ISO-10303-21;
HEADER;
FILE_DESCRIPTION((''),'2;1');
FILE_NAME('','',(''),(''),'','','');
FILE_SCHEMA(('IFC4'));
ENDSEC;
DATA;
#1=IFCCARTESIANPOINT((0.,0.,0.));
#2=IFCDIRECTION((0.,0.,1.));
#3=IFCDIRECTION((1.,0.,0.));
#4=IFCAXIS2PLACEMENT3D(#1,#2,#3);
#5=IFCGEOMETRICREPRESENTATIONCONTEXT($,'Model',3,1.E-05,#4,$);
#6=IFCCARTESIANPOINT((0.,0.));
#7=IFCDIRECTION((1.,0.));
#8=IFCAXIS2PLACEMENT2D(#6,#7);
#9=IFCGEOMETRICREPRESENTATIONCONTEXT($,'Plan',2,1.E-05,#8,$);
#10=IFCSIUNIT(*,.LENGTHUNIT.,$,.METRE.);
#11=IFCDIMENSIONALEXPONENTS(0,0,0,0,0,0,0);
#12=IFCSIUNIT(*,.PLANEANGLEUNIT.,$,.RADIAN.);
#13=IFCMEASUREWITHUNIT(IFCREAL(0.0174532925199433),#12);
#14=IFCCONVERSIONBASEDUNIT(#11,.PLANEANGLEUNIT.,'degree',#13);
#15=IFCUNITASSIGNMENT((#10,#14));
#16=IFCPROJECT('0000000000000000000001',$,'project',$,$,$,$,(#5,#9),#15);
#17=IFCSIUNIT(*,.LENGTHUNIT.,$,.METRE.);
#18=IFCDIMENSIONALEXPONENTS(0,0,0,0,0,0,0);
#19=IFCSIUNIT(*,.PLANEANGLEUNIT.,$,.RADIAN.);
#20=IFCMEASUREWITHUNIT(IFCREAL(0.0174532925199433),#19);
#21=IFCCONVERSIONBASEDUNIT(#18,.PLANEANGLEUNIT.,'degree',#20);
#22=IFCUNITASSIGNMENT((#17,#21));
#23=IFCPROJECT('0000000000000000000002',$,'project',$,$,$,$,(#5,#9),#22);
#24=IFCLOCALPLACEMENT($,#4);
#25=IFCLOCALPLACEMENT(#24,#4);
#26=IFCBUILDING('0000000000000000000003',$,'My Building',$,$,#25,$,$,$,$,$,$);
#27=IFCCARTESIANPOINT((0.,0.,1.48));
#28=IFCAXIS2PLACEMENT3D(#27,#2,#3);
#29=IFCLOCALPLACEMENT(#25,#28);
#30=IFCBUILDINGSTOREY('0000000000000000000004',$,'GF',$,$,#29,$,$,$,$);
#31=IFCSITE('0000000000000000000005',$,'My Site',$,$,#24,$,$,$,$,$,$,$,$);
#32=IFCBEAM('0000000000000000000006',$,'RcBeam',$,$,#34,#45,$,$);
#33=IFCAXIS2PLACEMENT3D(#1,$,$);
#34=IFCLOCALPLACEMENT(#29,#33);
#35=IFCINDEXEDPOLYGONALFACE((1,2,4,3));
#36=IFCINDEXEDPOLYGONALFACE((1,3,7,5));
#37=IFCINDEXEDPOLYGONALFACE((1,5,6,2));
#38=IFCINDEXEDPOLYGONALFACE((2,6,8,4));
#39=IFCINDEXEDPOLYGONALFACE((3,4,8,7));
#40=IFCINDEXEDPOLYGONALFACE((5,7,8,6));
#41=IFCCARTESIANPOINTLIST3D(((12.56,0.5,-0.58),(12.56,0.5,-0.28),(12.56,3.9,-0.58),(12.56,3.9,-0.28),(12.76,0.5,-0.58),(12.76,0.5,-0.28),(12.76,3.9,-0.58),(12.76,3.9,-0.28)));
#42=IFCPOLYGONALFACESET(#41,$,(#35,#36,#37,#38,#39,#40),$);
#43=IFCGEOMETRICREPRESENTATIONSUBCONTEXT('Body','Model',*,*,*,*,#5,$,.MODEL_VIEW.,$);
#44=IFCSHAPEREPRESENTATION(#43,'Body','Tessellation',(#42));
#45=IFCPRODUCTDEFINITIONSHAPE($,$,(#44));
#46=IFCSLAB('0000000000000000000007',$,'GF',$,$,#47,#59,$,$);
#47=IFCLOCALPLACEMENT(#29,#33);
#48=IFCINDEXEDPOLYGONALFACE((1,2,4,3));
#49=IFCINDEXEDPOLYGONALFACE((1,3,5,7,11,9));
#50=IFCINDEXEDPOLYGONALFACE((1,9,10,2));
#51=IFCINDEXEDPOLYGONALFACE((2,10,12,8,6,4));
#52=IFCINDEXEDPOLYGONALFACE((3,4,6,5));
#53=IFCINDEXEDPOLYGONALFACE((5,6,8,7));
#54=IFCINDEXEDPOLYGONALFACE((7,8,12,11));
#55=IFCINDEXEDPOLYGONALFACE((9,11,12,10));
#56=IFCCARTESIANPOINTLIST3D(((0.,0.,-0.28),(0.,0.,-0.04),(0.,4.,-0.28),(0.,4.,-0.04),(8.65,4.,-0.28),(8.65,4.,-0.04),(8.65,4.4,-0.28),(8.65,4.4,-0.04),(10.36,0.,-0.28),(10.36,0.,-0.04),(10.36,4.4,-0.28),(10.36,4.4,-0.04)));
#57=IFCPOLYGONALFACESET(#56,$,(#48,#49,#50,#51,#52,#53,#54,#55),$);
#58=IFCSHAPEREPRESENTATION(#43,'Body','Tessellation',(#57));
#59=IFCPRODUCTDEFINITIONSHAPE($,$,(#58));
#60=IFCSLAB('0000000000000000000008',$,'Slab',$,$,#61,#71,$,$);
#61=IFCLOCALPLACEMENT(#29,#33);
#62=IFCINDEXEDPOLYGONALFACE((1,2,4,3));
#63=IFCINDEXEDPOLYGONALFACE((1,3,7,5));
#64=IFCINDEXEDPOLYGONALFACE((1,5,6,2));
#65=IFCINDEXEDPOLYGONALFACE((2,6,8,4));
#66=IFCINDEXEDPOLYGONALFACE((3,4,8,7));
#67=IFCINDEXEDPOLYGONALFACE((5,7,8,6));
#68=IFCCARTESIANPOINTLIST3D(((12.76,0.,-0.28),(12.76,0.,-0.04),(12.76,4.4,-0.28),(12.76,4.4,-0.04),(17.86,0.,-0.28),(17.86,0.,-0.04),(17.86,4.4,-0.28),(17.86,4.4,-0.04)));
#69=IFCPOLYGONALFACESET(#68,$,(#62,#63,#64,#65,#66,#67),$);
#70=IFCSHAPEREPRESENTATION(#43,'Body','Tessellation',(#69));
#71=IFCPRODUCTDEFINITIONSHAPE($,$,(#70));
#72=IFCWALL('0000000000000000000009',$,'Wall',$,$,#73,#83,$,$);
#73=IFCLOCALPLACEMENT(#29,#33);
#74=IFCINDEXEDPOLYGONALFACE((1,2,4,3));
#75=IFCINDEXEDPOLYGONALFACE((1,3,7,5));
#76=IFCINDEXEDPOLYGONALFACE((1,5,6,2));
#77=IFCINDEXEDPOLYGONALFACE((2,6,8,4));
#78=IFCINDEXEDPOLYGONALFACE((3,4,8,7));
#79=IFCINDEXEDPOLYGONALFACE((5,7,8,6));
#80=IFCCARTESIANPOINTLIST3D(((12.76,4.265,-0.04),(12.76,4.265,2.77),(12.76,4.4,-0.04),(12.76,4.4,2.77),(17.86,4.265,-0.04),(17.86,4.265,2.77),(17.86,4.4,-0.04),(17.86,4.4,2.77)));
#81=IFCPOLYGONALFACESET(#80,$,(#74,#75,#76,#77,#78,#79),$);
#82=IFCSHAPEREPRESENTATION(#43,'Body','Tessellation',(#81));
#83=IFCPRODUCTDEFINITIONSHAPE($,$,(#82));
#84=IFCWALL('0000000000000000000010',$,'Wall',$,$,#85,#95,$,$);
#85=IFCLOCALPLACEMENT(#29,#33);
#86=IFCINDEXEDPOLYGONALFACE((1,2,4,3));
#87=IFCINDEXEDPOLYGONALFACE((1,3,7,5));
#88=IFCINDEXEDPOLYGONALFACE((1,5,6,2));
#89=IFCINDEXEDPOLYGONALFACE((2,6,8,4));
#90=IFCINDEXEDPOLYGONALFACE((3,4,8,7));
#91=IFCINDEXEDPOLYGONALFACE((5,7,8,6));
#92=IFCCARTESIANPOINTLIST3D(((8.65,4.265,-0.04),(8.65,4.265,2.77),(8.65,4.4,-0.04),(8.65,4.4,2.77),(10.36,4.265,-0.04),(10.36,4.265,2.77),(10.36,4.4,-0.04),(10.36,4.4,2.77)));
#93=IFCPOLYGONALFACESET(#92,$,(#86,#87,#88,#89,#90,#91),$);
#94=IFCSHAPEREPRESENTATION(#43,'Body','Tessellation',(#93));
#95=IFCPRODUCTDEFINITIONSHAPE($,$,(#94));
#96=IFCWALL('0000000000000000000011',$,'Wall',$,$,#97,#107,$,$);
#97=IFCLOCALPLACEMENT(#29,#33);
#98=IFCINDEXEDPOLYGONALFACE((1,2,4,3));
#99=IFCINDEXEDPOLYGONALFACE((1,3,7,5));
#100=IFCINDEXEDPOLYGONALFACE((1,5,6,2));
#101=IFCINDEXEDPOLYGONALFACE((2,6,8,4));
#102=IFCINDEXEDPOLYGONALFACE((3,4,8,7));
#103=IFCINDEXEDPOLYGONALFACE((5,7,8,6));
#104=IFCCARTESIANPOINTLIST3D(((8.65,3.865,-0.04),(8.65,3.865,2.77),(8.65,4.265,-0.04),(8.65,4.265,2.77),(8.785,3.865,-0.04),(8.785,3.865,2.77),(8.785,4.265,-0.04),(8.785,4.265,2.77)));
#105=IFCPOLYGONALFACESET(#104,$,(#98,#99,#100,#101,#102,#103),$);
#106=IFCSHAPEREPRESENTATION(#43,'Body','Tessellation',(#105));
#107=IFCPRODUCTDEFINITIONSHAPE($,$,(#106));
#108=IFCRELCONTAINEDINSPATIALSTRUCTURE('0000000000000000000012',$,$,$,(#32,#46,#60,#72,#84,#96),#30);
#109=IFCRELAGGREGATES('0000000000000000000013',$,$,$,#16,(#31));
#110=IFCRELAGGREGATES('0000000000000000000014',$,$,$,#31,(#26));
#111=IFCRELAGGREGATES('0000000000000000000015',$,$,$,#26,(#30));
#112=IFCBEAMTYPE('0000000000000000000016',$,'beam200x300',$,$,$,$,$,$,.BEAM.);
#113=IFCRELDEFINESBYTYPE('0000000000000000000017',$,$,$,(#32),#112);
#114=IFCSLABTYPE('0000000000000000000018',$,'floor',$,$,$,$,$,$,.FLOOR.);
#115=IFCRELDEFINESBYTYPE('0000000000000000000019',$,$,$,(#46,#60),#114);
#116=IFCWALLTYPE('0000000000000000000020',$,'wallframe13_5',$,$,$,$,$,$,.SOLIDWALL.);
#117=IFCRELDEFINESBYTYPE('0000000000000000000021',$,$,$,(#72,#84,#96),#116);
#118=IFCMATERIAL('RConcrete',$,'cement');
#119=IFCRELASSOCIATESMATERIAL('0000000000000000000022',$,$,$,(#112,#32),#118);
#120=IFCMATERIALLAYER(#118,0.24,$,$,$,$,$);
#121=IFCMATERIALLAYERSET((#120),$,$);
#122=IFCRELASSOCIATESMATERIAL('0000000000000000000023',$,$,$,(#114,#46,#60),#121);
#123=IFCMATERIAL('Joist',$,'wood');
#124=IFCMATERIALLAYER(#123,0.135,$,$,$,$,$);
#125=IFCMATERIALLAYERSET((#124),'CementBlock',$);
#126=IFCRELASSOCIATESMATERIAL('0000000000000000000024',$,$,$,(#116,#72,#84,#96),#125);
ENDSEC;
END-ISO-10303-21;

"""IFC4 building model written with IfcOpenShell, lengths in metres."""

from ifc_helpers import new_model, entity, si_unit, converted_unit, frame, origin_with_axes, origin_2d_with_axis, place, context, subcontext, project, spatial, line, indexed_curve, rectangle, outline, extrude, clip, halfspace, material, layer, layer_set, layer_usage, material_profile, profile_set, profile_usage, type_object, element, save


model = new_model("IFC4")

# Units and contexts
model_context = context("Model", 3, precision=1e-05, world=origin_with_axes())
plan_context = context("Plan", 2, precision=1e-05, world=origin_2d_with_axis())
body_context = subcontext(model_context, "Body", "Model", "MODEL_VIEW")
ifc_project_1 = project(units=[si_unit("LENGTHUNIT", "METRE"), converted_unit("PLANEANGLEUNIT", "degree", entity("IfcReal", 0.0174532925199433), si_unit("PLANEANGLEUNIT", "RADIAN"), dimensions=[0, 0, 0, 0, 0, 0, 0])], contexts=[model_context, plan_context])
ifc_project_2 = project(units=[si_unit("LENGTHUNIT", "METRE"), converted_unit("PLANEANGLEUNIT", "degree", entity("IfcReal", 0.0174532925199433), si_unit("PLANEANGLEUNIT", "RADIAN"), dimensions=[0, 0, 0, 0, 0, 0, 0])], contexts=[model_context, plan_context])

# Site, building, storey
site_placement = place(None, origin_with_axes())
site = spatial("IfcSite", under=ifc_project_1, at=site_placement, Name="My Site")
building_placement = place(site_placement, origin_with_axes())
building = spatial("IfcBuilding", under=site, at=building_placement, Name="My Building")
storey_placement = place(building_placement, frame((0.0, 0.0, 1.48), z_axis=(0.0, 0.0, 1.0), x_axis=(1.0, 0.0, 0.0)))
storey = spatial("IfcBuildingStorey", under=building, at=storey_placement, Name="GF")

# Shared definitions
ifc_material_1 = material(Name="RConcrete", Category="cement")

# Beam
ifc_material_profile_1 = material_profile(ifc_material_1, rectangle(XDim=0.2, YDim=0.3))
ifc_profile_set_1 = profile_set([ifc_material_profile_1], Name="RConcrete")
beam_type_1 = type_object("IfcBeamType", Name="beam200x300", PredefinedType="BEAM", material=ifc_profile_set_1)
ifc_profile_usage_1 = profile_usage(ifc_profile_set_1, cardinal=1)
beam_1_placement = place(storey_placement, frame((12.76, 3.9, -0.58), z_axis=(0.0, -1.0, 0.0), x_axis=(1.0, 0.0, 0.0)))
element("IfcBeam", 1, at=beam_1_placement, inside=storey, type_object=beam_type_1, material=ifc_profile_usage_1, Name="RcBeam", context=body_context, shape_type="SweptSolid", body=[
    extrude(rectangle(XDim=0.2, YDim=0.3), frame((-0.1, 0.15, 0.0), z_axis=(0.0, 0.0, 1.0), x_axis=(1.0, 0.0, 0.0)), (0.0, 0.0, 1.0), 3.4),
])

# Slabs
ifc_layer_1 = layer(ifc_material_1, 0.24)
ifc_layer_set_1 = layer_set([ifc_layer_1])
ifc_layer_usage_1 = layer_usage(ifc_layer_set_1, "AXIS3", "POSITIVE", 0.0)
slab_type = type_object("IfcSlabType", Name="floor", PredefinedType="FLOOR", material=ifc_layer_set_1)
slab_1_placement = place(storey_placement, frame((0.0, 0.0, -0.28), z_axis=(0.0, 0.0, 1.0), x_axis=(1.0, 0.0, 0.0)))
element("IfcSlab", 2, at=slab_1_placement, inside=storey, type_object=slab_type, material=ifc_layer_usage_1, Name="GF", context=body_context, shape_type="SweptSolid", body=[
    extrude(outline(indexed_curve([(0.0, 0.0), (10.36, 0.0), (10.36, 4.4), (0.0, 4.0), (8.65, 4.0), (8.65, 4.4)], segments=[line(1, 4), line(4, 5), line(5, 6), line(6, 3), line(3, 2), line(2, 1)], self_intersect=False)), None, (0.0, 0.0, 1.0), 0.24),
])
ifc_layer_usage_2 = layer_usage(ifc_layer_set_1, "AXIS3", "POSITIVE", 0.0)
slab_2_placement = place(storey_placement, frame((12.76, 0.0, -0.28), z_axis=(0.0, 0.0, 1.0), x_axis=(1.0, 0.0, 0.0)))
element("IfcSlab", 3, at=slab_2_placement, inside=storey, type_object=slab_type, material=ifc_layer_usage_2, Name="Slab", context=body_context, shape_type="SweptSolid", body=[
    extrude(outline(indexed_curve([(0.0, 4.4), (0.0, 0.0), (5.1, 0.0), (5.1, 4.4)], segments=[line(4, 1), line(1, 2), line(2, 3), line(3, 4)], self_intersect=False)), None, (0.0, 0.0, 1.0), 0.24),
])

# Walls
ifc_material_2 = material(Name="Joist", Category="wood")
ifc_layer_2 = layer(ifc_material_2, 0.135)
ifc_layer_set_2 = layer_set([ifc_layer_2], Name="CementBlock")
ifc_layer_usage_3 = layer_usage(ifc_layer_set_2, "AXIS2", "POSITIVE", 0.0)
wall_type = type_object("IfcWallType", Name="wallframe13_5", PredefinedType="SOLIDWALL", material=ifc_layer_set_2)
wall_1_placement = place(storey_placement, frame((17.86, 4.4, -0.04), z_axis=(0.0, 0.0, 1.0), x_axis=(-1.0, 0.0, 0.0)))
element("IfcWall", 4, at=wall_1_placement, inside=storey, type_object=wall_type, material=ifc_layer_usage_3, Name="Wall", context=body_context, shape_type="Clipping", body=[
    clip(extrude(outline(indexed_curve([(0.0, 0.0), (0.0, 0.135), (5.1, 0.135), (5.1, 0.0), (0.0, 0.0)], self_intersect=False)), origin_with_axes(), (0.0, 0.0, 1.0), 4.25), halfspace(frame((0.0, 0.0, 2.81), z_axis=(0.0, 0.0, 1.0), x_axis=(-1.0, 0.0, 0.0)), False)),
])
ifc_layer_usage_4 = layer_usage(ifc_layer_set_2, "AXIS2", "POSITIVE", 0.0)
wall_2_placement = place(storey_placement, frame((10.36, 4.4, -0.04), z_axis=(0.0, 0.0, 1.0), x_axis=(-1.0, 0.0, 0.0)))
element("IfcWall", 5, at=wall_2_placement, inside=storey, type_object=wall_type, material=ifc_layer_usage_4, Name="Wall", context=body_context, shape_type="Clipping", body=[
    clip(extrude(outline(indexed_curve([(0.0, 0.0), (0.0, 0.135), (1.71, 0.135), (1.71, 0.0), (0.0, 0.0)], self_intersect=False)), origin_with_axes(), (0.0, 0.0, 1.0), 4.25), halfspace(frame((0.0, 0.0, 2.81), z_axis=(0.0, 0.0, 1.0), x_axis=(-1.0, 0.0, 0.0)), False)),
])
ifc_layer_usage_5 = layer_usage(ifc_layer_set_2, "AXIS2", "POSITIVE", 0.0)
wall_3_placement = place(storey_placement, frame((8.65, 4.265, -0.04), z_axis=(0.0, 0.0, 1.0), x_axis=(-0.000001, -1.0, 0.0)))
element("IfcWall", 6, at=wall_3_placement, inside=storey, type_object=wall_type, material=ifc_layer_usage_5, Name="Wall", context=body_context, shape_type="Clipping", body=[
    clip(extrude(outline(indexed_curve([(0.0, 0.0), (0.0, 0.135), (0.4, 0.135), (0.4, 0.0), (0.0, 0.0)], self_intersect=False)), origin_with_axes(), (0.0, 0.0, 1.0), 4.25), halfspace(frame((0.0, 0.0, 2.81), z_axis=(0.0, 0.0, 1.0), x_axis=(-1.0, 0.0, 0.0)), False)),
])

save(model, "model.ifc")
